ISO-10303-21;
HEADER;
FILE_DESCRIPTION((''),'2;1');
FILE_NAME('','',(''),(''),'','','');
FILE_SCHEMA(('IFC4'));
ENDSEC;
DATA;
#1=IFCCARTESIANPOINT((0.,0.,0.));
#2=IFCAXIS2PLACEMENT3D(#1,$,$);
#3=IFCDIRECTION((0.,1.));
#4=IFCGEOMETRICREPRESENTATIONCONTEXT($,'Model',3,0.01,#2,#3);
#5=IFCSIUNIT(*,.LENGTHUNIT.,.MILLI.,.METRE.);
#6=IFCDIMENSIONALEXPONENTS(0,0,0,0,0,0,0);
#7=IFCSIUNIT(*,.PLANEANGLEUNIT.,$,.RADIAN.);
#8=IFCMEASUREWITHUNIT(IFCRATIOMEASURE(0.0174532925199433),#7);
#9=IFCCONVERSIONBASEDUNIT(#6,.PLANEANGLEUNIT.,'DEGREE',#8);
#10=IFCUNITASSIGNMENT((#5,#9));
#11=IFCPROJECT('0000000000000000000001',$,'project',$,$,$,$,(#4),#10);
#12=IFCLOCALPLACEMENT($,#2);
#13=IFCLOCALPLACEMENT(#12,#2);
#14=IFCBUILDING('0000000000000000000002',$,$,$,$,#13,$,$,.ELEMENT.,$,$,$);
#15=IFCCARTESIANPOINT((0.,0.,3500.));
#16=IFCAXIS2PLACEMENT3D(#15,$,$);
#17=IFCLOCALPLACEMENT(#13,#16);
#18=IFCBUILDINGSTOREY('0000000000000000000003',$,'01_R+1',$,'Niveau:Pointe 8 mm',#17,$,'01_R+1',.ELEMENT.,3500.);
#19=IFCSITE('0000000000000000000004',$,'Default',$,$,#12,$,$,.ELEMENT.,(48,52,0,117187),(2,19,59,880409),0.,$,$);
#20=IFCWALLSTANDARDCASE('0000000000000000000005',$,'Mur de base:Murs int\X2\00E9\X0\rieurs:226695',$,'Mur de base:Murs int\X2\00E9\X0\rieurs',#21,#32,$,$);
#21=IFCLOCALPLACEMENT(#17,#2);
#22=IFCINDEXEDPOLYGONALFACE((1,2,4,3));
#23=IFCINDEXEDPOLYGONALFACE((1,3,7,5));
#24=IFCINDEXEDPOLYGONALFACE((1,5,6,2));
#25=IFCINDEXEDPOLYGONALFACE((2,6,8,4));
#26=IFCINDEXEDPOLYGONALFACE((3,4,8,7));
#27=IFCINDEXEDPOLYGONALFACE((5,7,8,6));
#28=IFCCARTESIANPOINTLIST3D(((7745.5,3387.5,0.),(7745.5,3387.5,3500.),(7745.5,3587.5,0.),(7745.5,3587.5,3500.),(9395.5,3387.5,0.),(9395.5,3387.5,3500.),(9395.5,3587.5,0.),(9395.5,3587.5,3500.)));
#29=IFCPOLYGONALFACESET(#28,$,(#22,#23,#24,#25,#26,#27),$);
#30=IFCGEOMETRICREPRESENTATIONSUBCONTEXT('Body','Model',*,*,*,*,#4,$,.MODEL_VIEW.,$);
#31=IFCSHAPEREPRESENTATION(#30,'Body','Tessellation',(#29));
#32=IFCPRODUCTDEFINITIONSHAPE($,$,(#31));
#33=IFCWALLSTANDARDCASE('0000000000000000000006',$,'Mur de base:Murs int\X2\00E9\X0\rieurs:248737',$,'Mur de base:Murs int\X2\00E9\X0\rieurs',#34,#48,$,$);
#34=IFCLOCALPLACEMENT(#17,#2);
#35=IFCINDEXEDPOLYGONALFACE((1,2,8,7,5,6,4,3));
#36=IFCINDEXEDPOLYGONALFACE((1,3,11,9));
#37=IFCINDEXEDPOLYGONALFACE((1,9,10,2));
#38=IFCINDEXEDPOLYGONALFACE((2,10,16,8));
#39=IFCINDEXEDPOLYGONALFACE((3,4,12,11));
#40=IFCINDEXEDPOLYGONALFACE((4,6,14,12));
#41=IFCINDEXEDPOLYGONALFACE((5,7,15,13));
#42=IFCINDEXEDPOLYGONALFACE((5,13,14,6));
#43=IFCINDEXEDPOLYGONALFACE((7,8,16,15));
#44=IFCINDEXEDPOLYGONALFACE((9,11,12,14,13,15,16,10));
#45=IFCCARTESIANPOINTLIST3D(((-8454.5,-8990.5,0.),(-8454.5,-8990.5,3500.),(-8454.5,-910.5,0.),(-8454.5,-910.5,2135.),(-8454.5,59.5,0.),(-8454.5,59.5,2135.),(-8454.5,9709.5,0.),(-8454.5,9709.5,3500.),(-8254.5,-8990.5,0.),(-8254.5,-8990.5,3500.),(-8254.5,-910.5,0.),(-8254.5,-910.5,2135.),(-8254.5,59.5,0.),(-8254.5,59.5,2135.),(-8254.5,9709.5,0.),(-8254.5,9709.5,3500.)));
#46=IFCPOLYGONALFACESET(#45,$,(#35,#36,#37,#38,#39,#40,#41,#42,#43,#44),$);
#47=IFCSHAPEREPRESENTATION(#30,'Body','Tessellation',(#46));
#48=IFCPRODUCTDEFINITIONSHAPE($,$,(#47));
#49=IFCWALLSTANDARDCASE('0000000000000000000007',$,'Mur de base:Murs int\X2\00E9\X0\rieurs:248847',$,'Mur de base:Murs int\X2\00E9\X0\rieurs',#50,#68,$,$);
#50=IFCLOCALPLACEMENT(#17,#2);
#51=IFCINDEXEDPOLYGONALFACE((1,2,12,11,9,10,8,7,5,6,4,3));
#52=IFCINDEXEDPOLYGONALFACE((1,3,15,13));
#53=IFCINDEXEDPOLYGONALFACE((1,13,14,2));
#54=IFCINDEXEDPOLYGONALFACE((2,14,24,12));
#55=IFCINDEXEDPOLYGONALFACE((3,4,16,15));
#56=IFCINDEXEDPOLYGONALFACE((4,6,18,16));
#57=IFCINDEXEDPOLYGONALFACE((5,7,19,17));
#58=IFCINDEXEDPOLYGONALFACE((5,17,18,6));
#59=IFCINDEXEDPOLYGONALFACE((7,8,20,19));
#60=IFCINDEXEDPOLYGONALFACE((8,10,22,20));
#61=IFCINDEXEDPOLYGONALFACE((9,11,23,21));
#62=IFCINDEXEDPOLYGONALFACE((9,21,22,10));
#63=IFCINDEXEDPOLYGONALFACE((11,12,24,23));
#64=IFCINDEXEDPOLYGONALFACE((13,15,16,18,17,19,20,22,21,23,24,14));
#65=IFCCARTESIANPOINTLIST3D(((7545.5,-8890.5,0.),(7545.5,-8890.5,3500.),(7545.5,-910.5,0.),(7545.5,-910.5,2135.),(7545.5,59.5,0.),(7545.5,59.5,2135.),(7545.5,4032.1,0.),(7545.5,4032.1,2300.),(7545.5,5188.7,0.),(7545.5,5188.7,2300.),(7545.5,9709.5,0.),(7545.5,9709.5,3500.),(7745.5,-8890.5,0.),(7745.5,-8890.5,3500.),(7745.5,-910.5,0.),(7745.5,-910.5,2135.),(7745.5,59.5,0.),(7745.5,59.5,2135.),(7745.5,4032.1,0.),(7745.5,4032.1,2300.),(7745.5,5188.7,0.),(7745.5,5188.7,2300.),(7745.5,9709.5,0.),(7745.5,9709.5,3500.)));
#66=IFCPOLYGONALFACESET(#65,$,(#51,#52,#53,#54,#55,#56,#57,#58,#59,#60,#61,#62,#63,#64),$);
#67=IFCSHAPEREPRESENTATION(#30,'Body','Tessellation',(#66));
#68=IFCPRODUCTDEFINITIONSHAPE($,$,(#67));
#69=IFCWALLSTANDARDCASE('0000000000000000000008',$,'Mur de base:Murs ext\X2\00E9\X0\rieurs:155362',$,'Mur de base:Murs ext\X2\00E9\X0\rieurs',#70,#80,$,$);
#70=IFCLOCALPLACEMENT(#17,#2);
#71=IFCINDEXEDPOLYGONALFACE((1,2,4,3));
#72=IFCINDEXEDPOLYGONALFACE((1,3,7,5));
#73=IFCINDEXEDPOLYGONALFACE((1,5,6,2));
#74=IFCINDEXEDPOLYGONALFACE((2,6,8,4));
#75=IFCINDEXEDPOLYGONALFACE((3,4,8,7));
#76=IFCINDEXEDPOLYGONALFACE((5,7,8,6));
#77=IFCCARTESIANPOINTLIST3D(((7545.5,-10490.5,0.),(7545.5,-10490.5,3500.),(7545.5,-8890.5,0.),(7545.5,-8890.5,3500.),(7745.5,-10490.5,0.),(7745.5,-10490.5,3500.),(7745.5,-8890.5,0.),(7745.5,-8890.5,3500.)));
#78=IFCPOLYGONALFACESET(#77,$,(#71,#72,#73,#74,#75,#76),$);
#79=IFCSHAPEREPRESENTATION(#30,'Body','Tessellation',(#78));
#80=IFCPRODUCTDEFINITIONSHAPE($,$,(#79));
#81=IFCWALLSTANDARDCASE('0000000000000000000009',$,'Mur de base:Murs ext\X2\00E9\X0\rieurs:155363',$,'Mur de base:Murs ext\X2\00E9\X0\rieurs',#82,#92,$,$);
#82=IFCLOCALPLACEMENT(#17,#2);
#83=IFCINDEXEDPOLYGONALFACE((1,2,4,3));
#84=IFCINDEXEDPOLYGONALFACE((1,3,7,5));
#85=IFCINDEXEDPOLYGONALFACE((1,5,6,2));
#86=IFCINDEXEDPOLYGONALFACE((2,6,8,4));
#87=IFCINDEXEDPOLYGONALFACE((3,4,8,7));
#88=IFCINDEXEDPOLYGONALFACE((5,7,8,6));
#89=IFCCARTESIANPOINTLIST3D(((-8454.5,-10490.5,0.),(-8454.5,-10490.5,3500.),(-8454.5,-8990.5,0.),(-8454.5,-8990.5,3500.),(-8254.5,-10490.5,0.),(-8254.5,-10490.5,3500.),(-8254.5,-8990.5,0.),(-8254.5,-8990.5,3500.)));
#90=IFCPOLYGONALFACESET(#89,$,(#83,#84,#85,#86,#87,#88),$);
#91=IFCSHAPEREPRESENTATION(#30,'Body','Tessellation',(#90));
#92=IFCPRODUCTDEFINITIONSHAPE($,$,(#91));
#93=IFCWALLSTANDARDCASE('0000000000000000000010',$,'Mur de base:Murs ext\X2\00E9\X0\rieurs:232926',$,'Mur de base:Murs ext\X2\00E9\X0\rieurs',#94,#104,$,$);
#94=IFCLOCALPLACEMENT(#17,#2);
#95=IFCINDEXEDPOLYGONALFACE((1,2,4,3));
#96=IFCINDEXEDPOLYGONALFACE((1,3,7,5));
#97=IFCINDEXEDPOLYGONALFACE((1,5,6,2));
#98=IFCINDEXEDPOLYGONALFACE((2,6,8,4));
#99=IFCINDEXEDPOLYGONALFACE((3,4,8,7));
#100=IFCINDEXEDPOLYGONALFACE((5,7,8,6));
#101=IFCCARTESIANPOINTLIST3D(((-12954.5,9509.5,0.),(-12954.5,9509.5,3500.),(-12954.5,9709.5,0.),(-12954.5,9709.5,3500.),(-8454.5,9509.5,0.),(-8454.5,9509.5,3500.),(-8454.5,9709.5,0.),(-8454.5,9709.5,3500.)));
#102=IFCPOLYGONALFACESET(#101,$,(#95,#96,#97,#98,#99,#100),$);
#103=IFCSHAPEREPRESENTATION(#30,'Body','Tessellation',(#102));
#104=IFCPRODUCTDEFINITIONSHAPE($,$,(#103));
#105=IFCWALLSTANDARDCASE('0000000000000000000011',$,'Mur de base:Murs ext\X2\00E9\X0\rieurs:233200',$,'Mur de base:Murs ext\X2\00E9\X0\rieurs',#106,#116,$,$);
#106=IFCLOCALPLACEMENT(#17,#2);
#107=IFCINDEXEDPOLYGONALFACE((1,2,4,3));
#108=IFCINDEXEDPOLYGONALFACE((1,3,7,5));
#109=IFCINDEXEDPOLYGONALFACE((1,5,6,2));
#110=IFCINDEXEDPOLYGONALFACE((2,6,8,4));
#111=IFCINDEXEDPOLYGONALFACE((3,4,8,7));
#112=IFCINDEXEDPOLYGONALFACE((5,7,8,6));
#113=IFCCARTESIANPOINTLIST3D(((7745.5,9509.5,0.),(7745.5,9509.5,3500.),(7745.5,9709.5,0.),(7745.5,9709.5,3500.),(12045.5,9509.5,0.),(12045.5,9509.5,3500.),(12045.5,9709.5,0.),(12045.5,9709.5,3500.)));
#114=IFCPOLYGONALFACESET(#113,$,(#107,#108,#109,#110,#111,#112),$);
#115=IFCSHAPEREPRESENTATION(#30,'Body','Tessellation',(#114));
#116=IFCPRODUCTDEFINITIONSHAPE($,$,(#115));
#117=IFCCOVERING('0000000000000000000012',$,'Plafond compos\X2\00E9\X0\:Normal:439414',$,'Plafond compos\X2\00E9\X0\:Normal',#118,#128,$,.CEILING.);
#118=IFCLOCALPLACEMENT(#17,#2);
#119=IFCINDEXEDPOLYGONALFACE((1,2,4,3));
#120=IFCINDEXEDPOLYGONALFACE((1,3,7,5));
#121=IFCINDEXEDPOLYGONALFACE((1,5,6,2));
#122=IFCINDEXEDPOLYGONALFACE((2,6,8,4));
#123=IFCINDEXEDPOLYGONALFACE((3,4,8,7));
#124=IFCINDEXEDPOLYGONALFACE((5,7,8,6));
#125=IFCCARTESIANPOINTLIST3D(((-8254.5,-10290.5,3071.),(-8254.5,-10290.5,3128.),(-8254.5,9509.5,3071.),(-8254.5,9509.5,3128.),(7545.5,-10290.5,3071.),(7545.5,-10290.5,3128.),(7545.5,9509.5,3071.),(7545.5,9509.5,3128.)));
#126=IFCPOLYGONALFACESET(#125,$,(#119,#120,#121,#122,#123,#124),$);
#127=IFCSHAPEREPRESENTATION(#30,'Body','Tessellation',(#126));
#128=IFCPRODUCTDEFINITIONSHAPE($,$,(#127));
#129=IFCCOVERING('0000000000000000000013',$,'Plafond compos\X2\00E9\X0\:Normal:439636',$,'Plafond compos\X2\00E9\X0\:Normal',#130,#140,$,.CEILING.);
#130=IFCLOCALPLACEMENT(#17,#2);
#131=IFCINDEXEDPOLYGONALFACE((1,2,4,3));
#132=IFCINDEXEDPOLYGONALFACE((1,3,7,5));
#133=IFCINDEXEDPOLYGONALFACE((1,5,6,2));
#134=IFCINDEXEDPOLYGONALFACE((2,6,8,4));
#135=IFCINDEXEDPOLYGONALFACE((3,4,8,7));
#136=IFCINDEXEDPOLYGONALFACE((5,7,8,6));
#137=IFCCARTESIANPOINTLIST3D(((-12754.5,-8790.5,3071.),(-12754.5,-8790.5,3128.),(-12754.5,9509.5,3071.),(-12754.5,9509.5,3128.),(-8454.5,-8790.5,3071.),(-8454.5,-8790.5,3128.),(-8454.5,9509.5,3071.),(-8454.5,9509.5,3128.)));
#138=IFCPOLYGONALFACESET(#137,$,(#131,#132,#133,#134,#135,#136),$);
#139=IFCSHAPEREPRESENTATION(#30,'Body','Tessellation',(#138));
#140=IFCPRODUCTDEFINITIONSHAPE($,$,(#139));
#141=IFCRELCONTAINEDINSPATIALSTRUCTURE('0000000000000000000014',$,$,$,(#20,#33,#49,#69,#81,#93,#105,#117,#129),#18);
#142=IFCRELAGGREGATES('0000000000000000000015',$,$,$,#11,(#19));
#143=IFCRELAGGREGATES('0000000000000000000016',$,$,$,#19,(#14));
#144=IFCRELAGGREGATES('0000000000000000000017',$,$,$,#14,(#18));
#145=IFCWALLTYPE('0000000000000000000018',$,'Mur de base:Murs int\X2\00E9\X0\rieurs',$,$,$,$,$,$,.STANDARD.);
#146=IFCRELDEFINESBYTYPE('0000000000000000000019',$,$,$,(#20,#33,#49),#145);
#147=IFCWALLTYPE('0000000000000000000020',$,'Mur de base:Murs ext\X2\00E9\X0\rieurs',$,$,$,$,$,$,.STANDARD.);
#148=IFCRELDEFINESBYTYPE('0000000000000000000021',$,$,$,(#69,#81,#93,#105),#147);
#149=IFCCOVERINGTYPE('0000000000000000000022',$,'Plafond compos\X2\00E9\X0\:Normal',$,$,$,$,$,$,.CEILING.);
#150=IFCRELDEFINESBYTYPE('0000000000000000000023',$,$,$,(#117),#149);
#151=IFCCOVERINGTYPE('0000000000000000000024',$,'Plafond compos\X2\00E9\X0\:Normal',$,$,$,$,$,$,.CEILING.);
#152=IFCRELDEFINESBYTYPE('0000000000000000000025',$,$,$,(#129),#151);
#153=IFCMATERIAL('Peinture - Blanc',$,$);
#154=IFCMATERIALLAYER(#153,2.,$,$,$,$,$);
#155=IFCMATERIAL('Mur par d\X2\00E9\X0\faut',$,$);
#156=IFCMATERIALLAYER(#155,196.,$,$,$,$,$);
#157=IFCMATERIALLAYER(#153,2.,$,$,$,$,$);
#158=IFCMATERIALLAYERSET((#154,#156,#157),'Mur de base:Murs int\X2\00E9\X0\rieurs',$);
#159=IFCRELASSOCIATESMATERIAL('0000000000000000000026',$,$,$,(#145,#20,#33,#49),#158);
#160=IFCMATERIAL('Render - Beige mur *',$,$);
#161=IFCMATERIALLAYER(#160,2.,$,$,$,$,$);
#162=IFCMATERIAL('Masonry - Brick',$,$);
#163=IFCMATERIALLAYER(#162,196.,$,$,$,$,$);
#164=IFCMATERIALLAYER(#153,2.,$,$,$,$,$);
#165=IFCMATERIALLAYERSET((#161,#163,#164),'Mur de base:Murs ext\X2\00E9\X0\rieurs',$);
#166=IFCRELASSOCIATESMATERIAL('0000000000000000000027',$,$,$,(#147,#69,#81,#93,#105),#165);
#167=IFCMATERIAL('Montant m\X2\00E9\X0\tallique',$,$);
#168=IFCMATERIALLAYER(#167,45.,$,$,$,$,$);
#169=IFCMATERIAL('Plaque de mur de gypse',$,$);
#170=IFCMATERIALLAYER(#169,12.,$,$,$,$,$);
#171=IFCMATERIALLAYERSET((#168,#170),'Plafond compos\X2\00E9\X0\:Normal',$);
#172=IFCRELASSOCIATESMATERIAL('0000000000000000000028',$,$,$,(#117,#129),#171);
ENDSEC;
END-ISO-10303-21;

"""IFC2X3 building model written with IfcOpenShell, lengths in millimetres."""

from ifc_helpers import new_model, entity, si_unit, converted_unit, direction, frame, frame_2d, origin, origin_2d_with_axis, place, context, subcontext, project, spatial, rectangle, extrude, material, layer, layer_set, layer_usage, type_object, element, save


model = new_model("IFC2X3")

# Units and contexts
model_context = context("Model", 3, precision=0.01, world=origin(), true_north=direction((0.0, 1.0)))
body_context = subcontext(model_context, "Body", "Model", "MODEL_VIEW")
ifc_project = project(units=[si_unit("LENGTHUNIT", "METRE", prefix="MILLI"), converted_unit("PLANEANGLEUNIT", "DEGREE", entity("IfcRatioMeasure", 0.0174532925199433), si_unit("PLANEANGLEUNIT", "RADIAN"), dimensions=[0, 0, 0, 0, 0, 0, 0])], contexts=[model_context])

# Site, building, storey
site_placement = place(None, origin())
site = spatial("IfcSite", under=ifc_project, at=site_placement, Name="Default", CompositionType="ELEMENT", RefLatitude=(48, 52, 0, 117187), RefLongitude=(2, 19, 59, 880409), RefElevation=0.0)
building_placement = place(site_placement, origin())
building = spatial("IfcBuilding", under=site, at=building_placement, CompositionType="ELEMENT")
storey_placement = place(building_placement, frame((0.0, 0.0, 3500.0)))
storey = spatial("IfcBuildingStorey", under=building, at=storey_placement, Name="01_R+1", ObjectType="Niveau:Pointe 8 mm", LongName="01_R+1", CompositionType="ELEMENT", Elevation=3500.0)

# Shared definitions
ifc_material_1 = material(Name="Peinture - Blanc")
ifc_layer_1 = layer(ifc_material_1, 2.0)
ifc_material_2 = material(Name="Mur par défaut")
ifc_layer_2 = layer(ifc_material_2, 196.0)
ifc_layer_3 = layer(ifc_material_1, 2.0)
ifc_layer_set_1 = layer_set([ifc_layer_1, ifc_layer_2, ifc_layer_3], Name="Mur de base:Murs intérieurs")
wall_type_1 = type_object("IfcWallType", Name="Mur de base:Murs intérieurs", PredefinedType="STANDARD", material=ifc_layer_set_1)

# Wall
ifc_layer_usage_1 = layer_usage(ifc_layer_set_1, "AXIS2", "NEGATIVE", 100.0)
wall_1_placement = place(storey_placement, frame((9395.5, 3487.5, 0.0), z_axis=(0.0, 0.0, 1.0), x_axis=(-1.0, 0.0, 0.0)))
element("IfcWallStandardCase", 1, at=wall_1_placement, inside=storey, type_object=wall_type_1, material=ifc_layer_usage_1, Name="Mur de base:Murs intérieurs:226695", ObjectType="Mur de base:Murs intérieurs", context=body_context, shape_type="SweptSolid", body=[
    extrude(rectangle(XDim=1650.0, YDim=200.0, at=frame_2d((825.0, 0.0), x_axis=(-1.0, 0.0))), origin(), (0.0, 0.0, 1.0), 3500.0),
])

# Wall, opening
ifc_layer_usage_2 = layer_usage(ifc_layer_set_1, "AXIS2", "NEGATIVE", 100.0)
wall_2_placement = place(storey_placement, frame((-8354.5, -8990.5, 0.0), z_axis=(0.0, 0.0, 1.0), x_axis=(0.0, 1.0, 0.0)))
wall_2 = element("IfcWallStandardCase", 2, at=wall_2_placement, inside=storey, type_object=wall_type_1, material=ifc_layer_usage_2, Name="Mur de base:Murs intérieurs:248737", ObjectType="Mur de base:Murs intérieurs", context=body_context, shape_type="SweptSolid", body=[
    extrude(rectangle(XDim=18700.0, YDim=200.0, at=frame_2d((9350.0, 0.0), x_axis=(-1.0, 0.0))), origin(), (0.0, 0.0, 1.0), 3500.0),
])
opening_1_placement = place(wall_2_placement, frame((8080.0, -100.0, 0.0)))
element("IfcOpeningElement", 3, at=opening_1_placement, cuts=wall_2, ObjectType="Opening", context=body_context, shape_type="SweptSolid", body=[
    extrude(rectangle(XDim=2135.0, YDim=970.0, at=frame_2d((1067.5, 485.0), x_axis=(1.0, 0.0))), frame((0.0, 0.0, 0.0), z_axis=(0.0, 1.0, 0.0), x_axis=(0.0, 0.0, 1.0)), (0.0, 0.0, 1.0), 200.0),
])

# Wall, openings
ifc_layer_usage_3 = layer_usage(ifc_layer_set_1, "AXIS2", "NEGATIVE", 100.0)
wall_3_placement = place(storey_placement, frame((7645.5, -8890.5, 0.0), z_axis=(0.0, 0.0, 1.0), x_axis=(0.0, 1.0, 0.0)))
wall_3 = element("IfcWallStandardCase", 4, at=wall_3_placement, inside=storey, type_object=wall_type_1, material=ifc_layer_usage_3, Name="Mur de base:Murs intérieurs:248847", ObjectType="Mur de base:Murs intérieurs", context=body_context, shape_type="SweptSolid", body=[
    extrude(rectangle(XDim=18600.0, YDim=200.0, at=frame_2d((9300.0, 0.0), x_axis=(-1.0, 0.0))), origin(), (0.0, 0.0, 1.0), 3500.0),
])
opening_2_placement = place(wall_3_placement, origin())
element("IfcOpeningElement", 5, at=opening_2_placement, cuts=wall_3, ObjectType="Opening", context=body_context, shape_type="SweptSolid", body=[
    extrude(rectangle(XDim=2300.0, YDim=1156.6, at=origin_2d_with_axis()), frame((13501.0, -100.0, 1150.0), z_axis=(0.0, 1.0, 0.0), x_axis=(0.0, 0.0, -1.0)), (0.0, 0.0, 1.0), 200.0),
])
opening_3_placement = place(wall_3_placement, frame((8950.0, 100.0, 0.0)))
element("IfcOpeningElement", 6, at=opening_3_placement, cuts=wall_3, ObjectType="Opening", context=body_context, shape_type="SweptSolid", body=[
    extrude(rectangle(XDim=2135.0, YDim=970.0, at=frame_2d((1067.5, 485.0), x_axis=(1.0, 0.0))), frame((0.0, 0.0, 0.0), z_axis=(0.0, -1.0, 0.0), x_axis=(0.0, 0.0, 1.0)), (0.0, 0.0, 1.0), 200.0),
])

# Walls
ifc_material_3 = material(Name="Render - Beige mur *")
ifc_layer_4 = layer(ifc_material_3, 2.0)
ifc_material_4 = material(Name="Masonry - Brick")
ifc_layer_5 = layer(ifc_material_4, 196.0)
ifc_layer_6 = layer(ifc_material_1, 2.0)
ifc_layer_set_2 = layer_set([ifc_layer_4, ifc_layer_5, ifc_layer_6], Name="Mur de base:Murs extérieurs")
ifc_layer_usage_4 = layer_usage(ifc_layer_set_2, "AXIS2", "POSITIVE", -100.0)
wall_type_2 = type_object("IfcWallType", Name="Mur de base:Murs extérieurs", PredefinedType="STANDARD", material=ifc_layer_set_2)
wall_4_placement = place(storey_placement, frame((7645.5, -10490.5, 0.0), z_axis=(0.0, 0.0, 1.0), x_axis=(0.0, 1.0, 0.0)))
element("IfcWallStandardCase", 7, at=wall_4_placement, inside=storey, type_object=wall_type_2, material=ifc_layer_usage_4, Name="Mur de base:Murs extérieurs:155362", ObjectType="Mur de base:Murs extérieurs", context=body_context, shape_type="SweptSolid", body=[
    extrude(rectangle(XDim=1600.0, YDim=200.0, at=frame_2d((800.0, 0.0), x_axis=(-1.0, 0.0))), origin(), (0.0, 0.0, 1.0), 3500.0),
])
ifc_layer_usage_5 = layer_usage(ifc_layer_set_2, "AXIS2", "NEGATIVE", 100.0)
wall_5_placement = place(storey_placement, frame((-8354.5, -10490.5, 0.0), z_axis=(0.0, 0.0, 1.0), x_axis=(0.0, 1.0, 0.0)))
element("IfcWallStandardCase", 8, at=wall_5_placement, inside=storey, type_object=wall_type_2, material=ifc_layer_usage_5, Name="Mur de base:Murs extérieurs:155363", ObjectType="Mur de base:Murs extérieurs", context=body_context, shape_type="SweptSolid", body=[
    extrude(rectangle(XDim=1500.0, YDim=200.0, at=frame_2d((750.0, 0.0), x_axis=(-1.0, 0.0))), origin(), (0.0, 0.0, 1.0), 3500.0),
])
ifc_layer_usage_6 = layer_usage(ifc_layer_set_2, "AXIS2", "POSITIVE", -100.0)
wall_6_placement = place(storey_placement, frame((-8454.5, 9609.5, 0.0), z_axis=(0.0, 0.0, 1.0), x_axis=(-1.0, 0.0, 0.0)))
element("IfcWallStandardCase", 9, at=wall_6_placement, inside=storey, type_object=wall_type_2, material=ifc_layer_usage_6, Name="Mur de base:Murs extérieurs:232926", ObjectType="Mur de base:Murs extérieurs", context=body_context, shape_type="SweptSolid", body=[
    extrude(rectangle(XDim=4500.0, YDim=200.0, at=frame_2d((2250.0, 0.0), x_axis=(-1.0, 0.0))), origin(), (0.0, 0.0, 1.0), 3500.0),
])
ifc_layer_usage_7 = layer_usage(ifc_layer_set_2, "AXIS2", "POSITIVE", -100.0)
wall_7_placement = place(storey_placement, frame((12045.5, 9609.5, 0.0), z_axis=(0.0, 0.0, 1.0), x_axis=(-1.0, 0.0, 0.0)))
element("IfcWallStandardCase", 10, at=wall_7_placement, inside=storey, type_object=wall_type_2, material=ifc_layer_usage_7, Name="Mur de base:Murs extérieurs:233200", ObjectType="Mur de base:Murs extérieurs", context=body_context, shape_type="SweptSolid", body=[
    extrude(rectangle(XDim=4300.0, YDim=200.0, at=frame_2d((2150.0, 0.0), x_axis=(-1.0, 0.0))), origin(), (0.0, 0.0, 1.0), 3500.0),
])

# Coverings
ifc_material_5 = material(Name="Montant métallique")
ifc_layer_7 = layer(ifc_material_5, 45.0)
ifc_material_6 = material(Name="Plaque de mur de gypse")
ifc_layer_8 = layer(ifc_material_6, 12.0)
ifc_layer_set_3 = layer_set([ifc_layer_7, ifc_layer_8], Name="Plafond composé:Normal")
ifc_layer_usage_8 = layer_usage(ifc_layer_set_3, "AXIS3", "POSITIVE", 0.0)
covering_type_1 = type_object("IfcCoveringType", Name="Plafond composé:Normal", PredefinedType="CEILING")
covering_1_placement = place(storey_placement, origin())
element("IfcCovering", 11, at=covering_1_placement, inside=storey, type_object=covering_type_1, material=ifc_layer_usage_8, Name="Plafond composé:Normal:439414", ObjectType="Plafond composé:Normal", PredefinedType="CEILING", context=body_context, shape_type="SweptSolid", body=[
    extrude(rectangle(XDim=15800.0, YDim=19800.0, at=frame_2d((0.0, 0.0), x_axis=(1.0, 0.0))), frame((-354.5, -390.5, 3071.0), z_axis=(0.0, 0.0, 1.0), x_axis=(-1.0, 0.0, 0.0)), (0.0, 0.0, 1.0), 57.0),
])
ifc_layer_usage_9 = layer_usage(ifc_layer_set_3, "AXIS3", "POSITIVE", 0.0)
covering_type_2 = type_object("IfcCoveringType", Name="Plafond composé:Normal", PredefinedType="CEILING")
covering_2_placement = place(storey_placement, origin())
element("IfcCovering", 12, at=covering_2_placement, inside=storey, type_object=covering_type_2, material=ifc_layer_usage_9, Name="Plafond composé:Normal:439636", ObjectType="Plafond composé:Normal", PredefinedType="CEILING", context=body_context, shape_type="SweptSolid", body=[
    extrude(rectangle(XDim=4300.0, YDim=18300.0, at=frame_2d((0.0, 0.0), x_axis=(1.0, 0.0))), frame((-10604.5, 359.5, 3071.0), z_axis=(0.0, 0.0, 1.0), x_axis=(-1.0, 0.0, 0.0)), (0.0, 0.0, 1.0), 57.0),
])

save(model, "model.ifc")
